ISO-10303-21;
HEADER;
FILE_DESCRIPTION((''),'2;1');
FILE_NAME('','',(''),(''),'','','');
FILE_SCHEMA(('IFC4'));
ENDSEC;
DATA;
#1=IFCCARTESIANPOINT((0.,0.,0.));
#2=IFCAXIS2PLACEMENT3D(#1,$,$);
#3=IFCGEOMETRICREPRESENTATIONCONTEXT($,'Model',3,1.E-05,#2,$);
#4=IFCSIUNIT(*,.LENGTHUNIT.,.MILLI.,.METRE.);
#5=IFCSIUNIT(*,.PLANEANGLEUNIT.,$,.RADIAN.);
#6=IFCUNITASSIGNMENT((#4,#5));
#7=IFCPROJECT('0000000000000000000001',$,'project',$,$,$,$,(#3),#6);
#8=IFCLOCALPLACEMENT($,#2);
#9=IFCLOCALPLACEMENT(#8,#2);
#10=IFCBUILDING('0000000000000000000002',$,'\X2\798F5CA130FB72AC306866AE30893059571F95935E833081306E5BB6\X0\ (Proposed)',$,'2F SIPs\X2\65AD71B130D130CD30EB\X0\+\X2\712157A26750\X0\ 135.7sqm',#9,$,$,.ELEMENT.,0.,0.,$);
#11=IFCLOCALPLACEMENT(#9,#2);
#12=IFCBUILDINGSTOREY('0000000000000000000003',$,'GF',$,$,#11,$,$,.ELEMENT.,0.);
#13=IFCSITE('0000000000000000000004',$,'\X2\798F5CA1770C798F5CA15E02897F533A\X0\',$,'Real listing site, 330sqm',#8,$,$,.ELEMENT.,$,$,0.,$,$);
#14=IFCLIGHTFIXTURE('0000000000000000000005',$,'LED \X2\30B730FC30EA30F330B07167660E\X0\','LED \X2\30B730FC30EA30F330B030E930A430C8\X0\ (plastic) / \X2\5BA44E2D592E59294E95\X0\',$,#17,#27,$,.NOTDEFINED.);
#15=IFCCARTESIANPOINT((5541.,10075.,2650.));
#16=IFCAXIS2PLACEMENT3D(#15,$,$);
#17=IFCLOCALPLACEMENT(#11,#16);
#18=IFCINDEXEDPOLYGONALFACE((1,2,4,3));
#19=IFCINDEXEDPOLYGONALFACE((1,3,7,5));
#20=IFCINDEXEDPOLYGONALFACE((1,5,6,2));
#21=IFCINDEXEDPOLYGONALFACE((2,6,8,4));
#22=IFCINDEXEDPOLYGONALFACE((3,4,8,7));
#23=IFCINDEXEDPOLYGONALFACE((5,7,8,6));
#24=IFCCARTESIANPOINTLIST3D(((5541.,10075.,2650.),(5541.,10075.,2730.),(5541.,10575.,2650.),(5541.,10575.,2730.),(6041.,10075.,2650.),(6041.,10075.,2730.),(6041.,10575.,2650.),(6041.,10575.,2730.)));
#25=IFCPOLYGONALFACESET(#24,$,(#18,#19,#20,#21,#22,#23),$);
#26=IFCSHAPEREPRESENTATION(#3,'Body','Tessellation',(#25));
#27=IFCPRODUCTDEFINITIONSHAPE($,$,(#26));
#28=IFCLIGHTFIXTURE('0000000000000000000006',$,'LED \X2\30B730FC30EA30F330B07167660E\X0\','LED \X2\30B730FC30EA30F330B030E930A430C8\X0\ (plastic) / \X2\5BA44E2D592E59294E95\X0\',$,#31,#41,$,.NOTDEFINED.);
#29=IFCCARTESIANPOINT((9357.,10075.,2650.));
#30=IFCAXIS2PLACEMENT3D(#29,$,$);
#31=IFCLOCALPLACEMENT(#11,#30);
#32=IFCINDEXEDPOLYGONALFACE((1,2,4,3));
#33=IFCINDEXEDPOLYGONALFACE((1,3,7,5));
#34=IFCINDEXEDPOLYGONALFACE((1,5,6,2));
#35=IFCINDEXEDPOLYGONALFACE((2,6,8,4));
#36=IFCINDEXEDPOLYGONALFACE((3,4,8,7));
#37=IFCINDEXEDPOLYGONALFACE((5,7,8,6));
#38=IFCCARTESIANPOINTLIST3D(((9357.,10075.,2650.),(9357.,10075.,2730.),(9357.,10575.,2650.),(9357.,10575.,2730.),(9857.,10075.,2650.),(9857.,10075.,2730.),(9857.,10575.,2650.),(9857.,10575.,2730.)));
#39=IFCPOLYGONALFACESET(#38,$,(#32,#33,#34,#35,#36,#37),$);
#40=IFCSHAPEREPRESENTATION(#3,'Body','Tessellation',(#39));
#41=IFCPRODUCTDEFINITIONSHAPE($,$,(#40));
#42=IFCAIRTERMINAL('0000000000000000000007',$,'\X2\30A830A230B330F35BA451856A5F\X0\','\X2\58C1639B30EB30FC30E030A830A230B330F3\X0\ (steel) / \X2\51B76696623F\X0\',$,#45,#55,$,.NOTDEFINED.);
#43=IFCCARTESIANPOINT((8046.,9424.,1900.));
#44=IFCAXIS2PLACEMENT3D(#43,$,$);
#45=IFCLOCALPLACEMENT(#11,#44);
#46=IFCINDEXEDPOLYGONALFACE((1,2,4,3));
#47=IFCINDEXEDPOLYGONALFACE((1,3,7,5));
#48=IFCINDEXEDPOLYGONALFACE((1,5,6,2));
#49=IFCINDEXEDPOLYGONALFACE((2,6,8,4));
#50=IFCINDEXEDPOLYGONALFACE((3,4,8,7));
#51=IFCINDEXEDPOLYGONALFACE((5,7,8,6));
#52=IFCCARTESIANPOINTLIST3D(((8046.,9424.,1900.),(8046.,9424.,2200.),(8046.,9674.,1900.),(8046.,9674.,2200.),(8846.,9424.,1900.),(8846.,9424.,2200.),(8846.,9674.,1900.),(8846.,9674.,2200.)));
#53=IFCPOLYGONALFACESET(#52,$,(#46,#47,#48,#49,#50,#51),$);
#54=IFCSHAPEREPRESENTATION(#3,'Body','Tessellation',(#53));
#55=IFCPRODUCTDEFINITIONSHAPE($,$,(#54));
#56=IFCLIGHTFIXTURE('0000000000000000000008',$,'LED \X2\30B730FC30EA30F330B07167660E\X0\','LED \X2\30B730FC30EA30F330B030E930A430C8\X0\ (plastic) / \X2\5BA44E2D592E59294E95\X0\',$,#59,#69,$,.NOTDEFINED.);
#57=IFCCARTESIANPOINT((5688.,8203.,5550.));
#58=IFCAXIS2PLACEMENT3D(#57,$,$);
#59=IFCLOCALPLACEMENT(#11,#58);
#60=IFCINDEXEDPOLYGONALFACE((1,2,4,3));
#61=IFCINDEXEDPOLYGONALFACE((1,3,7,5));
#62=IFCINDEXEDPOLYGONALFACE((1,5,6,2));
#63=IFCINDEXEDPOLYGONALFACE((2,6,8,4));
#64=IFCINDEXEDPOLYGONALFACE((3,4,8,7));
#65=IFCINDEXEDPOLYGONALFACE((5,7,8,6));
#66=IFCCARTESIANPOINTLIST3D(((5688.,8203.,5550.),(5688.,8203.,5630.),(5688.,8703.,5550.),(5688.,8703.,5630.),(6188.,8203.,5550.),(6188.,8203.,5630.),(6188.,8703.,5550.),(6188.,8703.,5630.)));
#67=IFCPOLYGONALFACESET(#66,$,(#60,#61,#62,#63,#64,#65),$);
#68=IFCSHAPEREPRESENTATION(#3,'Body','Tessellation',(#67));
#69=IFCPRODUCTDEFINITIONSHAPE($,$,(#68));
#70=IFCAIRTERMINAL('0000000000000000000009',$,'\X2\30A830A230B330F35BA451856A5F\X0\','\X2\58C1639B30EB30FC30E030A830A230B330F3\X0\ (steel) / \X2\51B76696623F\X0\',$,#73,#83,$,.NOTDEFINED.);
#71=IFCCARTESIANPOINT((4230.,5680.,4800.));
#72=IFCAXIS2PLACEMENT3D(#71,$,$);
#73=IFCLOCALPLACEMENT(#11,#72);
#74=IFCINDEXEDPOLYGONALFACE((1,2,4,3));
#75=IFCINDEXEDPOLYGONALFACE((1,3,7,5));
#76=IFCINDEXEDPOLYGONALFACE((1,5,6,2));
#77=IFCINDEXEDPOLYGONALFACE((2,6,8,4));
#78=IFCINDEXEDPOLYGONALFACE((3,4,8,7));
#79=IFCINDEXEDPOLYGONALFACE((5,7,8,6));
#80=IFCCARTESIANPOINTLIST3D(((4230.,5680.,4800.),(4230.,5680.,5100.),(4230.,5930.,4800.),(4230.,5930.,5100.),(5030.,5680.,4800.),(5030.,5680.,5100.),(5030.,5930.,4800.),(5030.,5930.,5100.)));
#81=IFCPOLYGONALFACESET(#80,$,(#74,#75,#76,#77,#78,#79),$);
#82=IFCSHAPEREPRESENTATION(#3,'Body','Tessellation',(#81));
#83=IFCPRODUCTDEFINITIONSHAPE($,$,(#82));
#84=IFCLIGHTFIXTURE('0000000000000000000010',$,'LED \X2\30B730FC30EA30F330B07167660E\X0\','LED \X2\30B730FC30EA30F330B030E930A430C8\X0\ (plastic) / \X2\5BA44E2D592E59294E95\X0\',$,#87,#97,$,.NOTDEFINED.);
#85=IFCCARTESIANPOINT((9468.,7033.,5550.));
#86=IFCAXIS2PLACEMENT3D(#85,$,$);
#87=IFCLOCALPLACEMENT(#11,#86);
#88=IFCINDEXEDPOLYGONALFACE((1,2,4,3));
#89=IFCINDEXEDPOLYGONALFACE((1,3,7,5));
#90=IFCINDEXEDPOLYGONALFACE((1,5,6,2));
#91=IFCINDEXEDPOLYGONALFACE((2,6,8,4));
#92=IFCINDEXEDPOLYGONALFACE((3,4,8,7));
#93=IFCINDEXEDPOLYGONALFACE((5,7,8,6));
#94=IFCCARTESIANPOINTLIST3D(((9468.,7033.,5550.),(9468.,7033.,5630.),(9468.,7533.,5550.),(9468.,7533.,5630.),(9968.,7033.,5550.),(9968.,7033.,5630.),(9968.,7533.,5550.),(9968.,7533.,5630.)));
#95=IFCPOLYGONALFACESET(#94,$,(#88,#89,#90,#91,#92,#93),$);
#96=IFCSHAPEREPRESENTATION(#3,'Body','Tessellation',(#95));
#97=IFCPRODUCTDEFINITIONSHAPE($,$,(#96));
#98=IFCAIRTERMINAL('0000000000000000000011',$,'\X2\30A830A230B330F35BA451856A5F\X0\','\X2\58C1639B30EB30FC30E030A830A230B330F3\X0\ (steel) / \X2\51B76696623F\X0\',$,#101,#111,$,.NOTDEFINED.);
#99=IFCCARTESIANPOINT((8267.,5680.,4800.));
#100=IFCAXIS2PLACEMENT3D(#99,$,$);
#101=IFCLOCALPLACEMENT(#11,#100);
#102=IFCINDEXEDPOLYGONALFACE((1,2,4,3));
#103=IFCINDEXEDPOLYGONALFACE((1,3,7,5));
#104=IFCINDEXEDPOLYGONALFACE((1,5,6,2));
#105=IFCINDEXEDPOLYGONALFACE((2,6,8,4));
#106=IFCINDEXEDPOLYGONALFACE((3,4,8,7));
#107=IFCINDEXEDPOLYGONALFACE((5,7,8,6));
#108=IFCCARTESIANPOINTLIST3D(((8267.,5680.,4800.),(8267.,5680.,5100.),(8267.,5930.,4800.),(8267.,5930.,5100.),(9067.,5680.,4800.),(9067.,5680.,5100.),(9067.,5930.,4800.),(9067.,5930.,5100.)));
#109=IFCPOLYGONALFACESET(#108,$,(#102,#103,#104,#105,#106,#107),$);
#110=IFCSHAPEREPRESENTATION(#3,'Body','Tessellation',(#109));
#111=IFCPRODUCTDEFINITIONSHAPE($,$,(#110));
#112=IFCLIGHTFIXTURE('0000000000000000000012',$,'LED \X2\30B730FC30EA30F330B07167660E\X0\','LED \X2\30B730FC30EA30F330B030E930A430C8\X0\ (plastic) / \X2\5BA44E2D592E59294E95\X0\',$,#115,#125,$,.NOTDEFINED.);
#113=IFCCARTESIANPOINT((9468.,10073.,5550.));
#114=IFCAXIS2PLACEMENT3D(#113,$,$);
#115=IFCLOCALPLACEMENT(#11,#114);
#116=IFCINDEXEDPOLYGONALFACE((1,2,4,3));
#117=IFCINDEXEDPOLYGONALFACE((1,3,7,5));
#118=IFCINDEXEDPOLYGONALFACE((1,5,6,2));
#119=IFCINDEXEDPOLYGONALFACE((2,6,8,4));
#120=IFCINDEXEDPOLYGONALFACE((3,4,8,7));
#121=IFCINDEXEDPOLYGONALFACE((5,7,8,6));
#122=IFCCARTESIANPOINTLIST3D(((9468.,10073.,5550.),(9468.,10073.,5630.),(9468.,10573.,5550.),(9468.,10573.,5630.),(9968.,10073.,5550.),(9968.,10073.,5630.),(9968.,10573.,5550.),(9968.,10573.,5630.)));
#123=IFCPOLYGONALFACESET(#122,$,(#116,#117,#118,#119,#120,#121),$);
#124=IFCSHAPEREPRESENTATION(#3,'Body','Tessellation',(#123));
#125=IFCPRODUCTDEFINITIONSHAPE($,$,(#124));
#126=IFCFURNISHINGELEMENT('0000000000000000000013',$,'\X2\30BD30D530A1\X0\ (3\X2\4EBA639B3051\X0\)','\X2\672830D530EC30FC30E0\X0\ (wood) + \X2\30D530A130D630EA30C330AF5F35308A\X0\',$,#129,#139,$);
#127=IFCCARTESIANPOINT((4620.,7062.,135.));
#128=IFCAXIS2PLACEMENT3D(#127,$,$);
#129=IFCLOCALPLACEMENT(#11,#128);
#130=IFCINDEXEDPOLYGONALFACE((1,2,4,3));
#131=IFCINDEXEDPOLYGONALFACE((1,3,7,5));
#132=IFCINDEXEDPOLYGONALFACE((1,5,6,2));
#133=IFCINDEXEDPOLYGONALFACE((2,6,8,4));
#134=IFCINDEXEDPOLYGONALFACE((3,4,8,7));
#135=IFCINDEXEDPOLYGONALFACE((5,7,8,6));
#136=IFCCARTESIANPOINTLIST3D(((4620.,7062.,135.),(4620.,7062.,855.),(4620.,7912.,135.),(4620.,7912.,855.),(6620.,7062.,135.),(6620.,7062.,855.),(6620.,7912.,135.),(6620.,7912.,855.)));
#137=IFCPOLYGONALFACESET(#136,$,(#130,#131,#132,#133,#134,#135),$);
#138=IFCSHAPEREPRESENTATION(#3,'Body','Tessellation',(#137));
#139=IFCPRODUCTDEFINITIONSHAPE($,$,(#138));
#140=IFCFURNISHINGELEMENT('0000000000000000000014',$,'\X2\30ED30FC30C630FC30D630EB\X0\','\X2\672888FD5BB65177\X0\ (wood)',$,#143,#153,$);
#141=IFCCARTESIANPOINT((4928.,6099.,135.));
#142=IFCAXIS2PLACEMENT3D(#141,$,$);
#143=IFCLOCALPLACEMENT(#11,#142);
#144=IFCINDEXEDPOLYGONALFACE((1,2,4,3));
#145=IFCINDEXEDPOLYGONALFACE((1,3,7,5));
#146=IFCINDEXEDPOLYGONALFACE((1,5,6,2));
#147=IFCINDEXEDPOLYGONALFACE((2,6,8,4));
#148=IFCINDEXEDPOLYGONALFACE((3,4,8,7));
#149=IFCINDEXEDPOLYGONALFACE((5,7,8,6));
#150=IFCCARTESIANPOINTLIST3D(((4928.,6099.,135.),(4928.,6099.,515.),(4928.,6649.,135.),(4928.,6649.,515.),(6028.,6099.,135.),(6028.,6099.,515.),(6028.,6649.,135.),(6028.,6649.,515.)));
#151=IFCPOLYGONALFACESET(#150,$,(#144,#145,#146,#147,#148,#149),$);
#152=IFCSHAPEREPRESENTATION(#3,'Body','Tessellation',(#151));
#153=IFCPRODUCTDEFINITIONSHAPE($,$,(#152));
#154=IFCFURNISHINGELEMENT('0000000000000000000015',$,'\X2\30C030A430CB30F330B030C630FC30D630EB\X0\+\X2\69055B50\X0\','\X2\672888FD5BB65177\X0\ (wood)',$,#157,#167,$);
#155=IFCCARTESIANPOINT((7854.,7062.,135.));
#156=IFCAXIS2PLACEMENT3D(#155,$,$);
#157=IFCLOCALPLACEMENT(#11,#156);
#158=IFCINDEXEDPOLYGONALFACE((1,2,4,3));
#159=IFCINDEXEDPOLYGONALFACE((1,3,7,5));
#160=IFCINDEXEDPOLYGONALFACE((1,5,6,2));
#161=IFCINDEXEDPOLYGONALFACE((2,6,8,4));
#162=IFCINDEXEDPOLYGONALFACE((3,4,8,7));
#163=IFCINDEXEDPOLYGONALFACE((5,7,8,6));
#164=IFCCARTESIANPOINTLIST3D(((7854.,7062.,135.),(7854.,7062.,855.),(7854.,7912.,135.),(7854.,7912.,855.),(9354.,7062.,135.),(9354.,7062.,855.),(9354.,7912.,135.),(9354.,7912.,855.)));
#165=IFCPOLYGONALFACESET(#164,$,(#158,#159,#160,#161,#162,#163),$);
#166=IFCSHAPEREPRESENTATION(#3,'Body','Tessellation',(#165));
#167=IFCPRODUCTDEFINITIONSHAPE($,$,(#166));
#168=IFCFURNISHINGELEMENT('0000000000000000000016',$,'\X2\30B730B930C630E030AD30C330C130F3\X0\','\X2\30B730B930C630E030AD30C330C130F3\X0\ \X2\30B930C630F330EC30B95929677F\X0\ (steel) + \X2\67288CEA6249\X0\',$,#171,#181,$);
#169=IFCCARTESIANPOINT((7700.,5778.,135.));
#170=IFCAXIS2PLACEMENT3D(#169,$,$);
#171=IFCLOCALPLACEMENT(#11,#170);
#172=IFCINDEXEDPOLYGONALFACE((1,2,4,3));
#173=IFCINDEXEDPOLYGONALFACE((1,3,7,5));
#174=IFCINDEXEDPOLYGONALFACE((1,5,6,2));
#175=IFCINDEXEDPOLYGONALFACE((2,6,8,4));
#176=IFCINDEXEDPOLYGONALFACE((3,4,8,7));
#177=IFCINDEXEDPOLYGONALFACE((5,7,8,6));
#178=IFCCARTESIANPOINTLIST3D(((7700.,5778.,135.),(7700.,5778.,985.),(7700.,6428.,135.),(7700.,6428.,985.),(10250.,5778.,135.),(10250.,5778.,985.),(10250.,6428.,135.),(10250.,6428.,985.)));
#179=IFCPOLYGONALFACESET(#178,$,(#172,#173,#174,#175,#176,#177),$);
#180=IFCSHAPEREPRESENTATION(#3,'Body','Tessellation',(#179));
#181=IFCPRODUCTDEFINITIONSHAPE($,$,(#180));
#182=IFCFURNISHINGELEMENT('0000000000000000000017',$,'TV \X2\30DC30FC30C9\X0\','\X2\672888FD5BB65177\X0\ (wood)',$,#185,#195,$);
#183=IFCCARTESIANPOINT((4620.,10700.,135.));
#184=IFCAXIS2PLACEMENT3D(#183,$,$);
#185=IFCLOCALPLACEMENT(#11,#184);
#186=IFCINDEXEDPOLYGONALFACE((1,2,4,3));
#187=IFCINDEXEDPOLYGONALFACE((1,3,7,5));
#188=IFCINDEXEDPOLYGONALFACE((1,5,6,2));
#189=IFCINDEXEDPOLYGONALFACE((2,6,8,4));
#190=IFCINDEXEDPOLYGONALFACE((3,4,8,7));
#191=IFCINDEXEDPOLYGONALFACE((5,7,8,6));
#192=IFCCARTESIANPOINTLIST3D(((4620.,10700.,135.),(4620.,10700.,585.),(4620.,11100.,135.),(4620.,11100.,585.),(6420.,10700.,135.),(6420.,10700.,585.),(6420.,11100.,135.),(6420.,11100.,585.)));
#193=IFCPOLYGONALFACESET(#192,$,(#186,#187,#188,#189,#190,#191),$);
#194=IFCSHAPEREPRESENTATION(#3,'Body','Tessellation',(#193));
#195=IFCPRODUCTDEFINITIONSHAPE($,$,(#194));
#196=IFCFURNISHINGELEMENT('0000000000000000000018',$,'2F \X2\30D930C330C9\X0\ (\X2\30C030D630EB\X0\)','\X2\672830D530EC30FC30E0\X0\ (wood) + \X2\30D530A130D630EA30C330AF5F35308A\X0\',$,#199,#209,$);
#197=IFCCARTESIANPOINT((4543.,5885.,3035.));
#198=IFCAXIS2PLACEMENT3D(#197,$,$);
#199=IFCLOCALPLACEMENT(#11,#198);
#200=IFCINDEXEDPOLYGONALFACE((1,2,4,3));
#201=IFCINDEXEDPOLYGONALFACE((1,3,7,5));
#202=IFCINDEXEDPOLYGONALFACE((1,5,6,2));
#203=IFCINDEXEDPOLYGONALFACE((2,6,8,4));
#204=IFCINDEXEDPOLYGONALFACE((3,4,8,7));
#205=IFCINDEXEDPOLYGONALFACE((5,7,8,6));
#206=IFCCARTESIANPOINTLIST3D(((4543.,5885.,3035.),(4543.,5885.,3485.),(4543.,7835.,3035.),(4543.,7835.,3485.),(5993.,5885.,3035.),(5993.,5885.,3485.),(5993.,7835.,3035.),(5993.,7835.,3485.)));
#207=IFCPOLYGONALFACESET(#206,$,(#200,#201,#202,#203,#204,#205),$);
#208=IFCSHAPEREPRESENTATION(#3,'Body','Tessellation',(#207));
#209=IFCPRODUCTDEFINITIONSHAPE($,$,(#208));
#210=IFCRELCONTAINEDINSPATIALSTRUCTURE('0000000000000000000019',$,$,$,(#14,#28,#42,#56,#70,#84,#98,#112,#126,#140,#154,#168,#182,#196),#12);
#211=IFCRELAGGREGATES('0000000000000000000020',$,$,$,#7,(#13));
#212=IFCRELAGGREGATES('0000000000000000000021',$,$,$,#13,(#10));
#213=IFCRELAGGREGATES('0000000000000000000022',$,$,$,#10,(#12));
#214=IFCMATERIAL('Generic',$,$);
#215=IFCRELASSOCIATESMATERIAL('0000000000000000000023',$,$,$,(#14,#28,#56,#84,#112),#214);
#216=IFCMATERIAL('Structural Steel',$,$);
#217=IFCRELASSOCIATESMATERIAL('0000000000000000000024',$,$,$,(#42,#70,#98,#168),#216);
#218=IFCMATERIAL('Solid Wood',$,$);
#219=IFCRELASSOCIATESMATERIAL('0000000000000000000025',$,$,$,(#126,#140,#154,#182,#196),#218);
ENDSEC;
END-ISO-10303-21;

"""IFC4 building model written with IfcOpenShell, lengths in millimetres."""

from ifc_helpers import new_model, si_unit, frame, frame_2d, origin, place, context, project, spatial, rectangle, extrude, material, element, save


model = new_model("IFC4")

# Units and contexts
model_context = context("Model", 3, precision=1e-05, world=origin())
ifc_project = project(units=[si_unit("LENGTHUNIT", "METRE", prefix="MILLI"), si_unit("PLANEANGLEUNIT", "RADIAN")], contexts=[model_context])

# Site, building, storey
site_placement = place(None, origin())
site = spatial("IfcSite", under=ifc_project, at=site_placement, Name="福岡県福岡市西区", ObjectType="Real listing site, 330sqm", CompositionType="ELEMENT", RefElevation=0.0)
building_placement = place(site_placement, origin())
building = spatial("IfcBuilding", under=site, at=building_placement, Name="福岡・犬と暮らす土間広めの家 (Proposed)", ObjectType="2F SIPs断熱パネル+無垢材 135.7sqm", CompositionType="ELEMENT", ElevationOfRefHeight=0.0, ElevationOfTerrain=0.0)
storey_placement = place(building_placement, origin())
storey = spatial("IfcBuildingStorey", under=building, at=storey_placement, Name="GF", CompositionType="ELEMENT", Elevation=0.0)

# Shared definitions
ifc_material_1 = material(Name="Solid Wood")

# Shared definitions
ifc_material_2 = material(Name="Structural Steel")

# Shared definitions
ifc_material_3 = material(Name="Generic")

# Light fixtures
light_fixture_1_placement = place(storey_placement, frame((5541.0, 10075.0, 2650.0)))
element("IfcLightFixture", 1, at=light_fixture_1_placement, inside=storey, material=ifc_material_3, Name="LED シーリング照明", Description="LED シーリングライト (plastic) / 室中央天井", PredefinedType="NOTDEFINED", context=model_context, shape_type="SweptSolid", body=[
    extrude(rectangle(XDim=500.0, YDim=500.0, at=frame_2d((250.0, 250.0))), frame((5541.0, 10075.0, 2650.0)), (0.0, 0.0, 1.0), 80.0),
])
light_fixture_2_placement = place(storey_placement, frame((9357.0, 10075.0, 2650.0)))
element("IfcLightFixture", 2, at=light_fixture_2_placement, inside=storey, material=ifc_material_3, Name="LED シーリング照明", Description="LED シーリングライト (plastic) / 室中央天井", PredefinedType="NOTDEFINED", context=model_context, shape_type="SweptSolid", body=[
    extrude(rectangle(XDim=500.0, YDim=500.0, at=frame_2d((250.0, 250.0))), frame((9357.0, 10075.0, 2650.0)), (0.0, 0.0, 1.0), 80.0),
])

# Air terminal
air_terminal_1_placement = place(storey_placement, frame((8046.0, 9424.0, 1900.0)))
element("IfcAirTerminal", 3, at=air_terminal_1_placement, inside=storey, material=ifc_material_2, Name="エアコン室内機", Description="壁掛ルームエアコン (steel) / 冷暖房", PredefinedType="NOTDEFINED", context=model_context, shape_type="SweptSolid", body=[
    extrude(rectangle(XDim=800.0, YDim=250.0, at=frame_2d((400.0, 125.0))), frame((8046.0, 9424.0, 1900.0)), (0.0, 0.0, 1.0), 300.0),
])

# Light fixture
light_fixture_3_placement = place(storey_placement, frame((5688.0, 8203.0, 5550.0)))
element("IfcLightFixture", 4, at=light_fixture_3_placement, inside=storey, material=ifc_material_3, Name="LED シーリング照明", Description="LED シーリングライト (plastic) / 室中央天井", PredefinedType="NOTDEFINED", context=model_context, shape_type="SweptSolid", body=[
    extrude(rectangle(XDim=500.0, YDim=500.0, at=frame_2d((250.0, 250.0))), frame((5688.0, 8203.0, 5550.0)), (0.0, 0.0, 1.0), 80.0),
])

# Air terminal
air_terminal_2_placement = place(storey_placement, frame((4230.0, 5680.0, 4800.0)))
element("IfcAirTerminal", 5, at=air_terminal_2_placement, inside=storey, material=ifc_material_2, Name="エアコン室内機", Description="壁掛ルームエアコン (steel) / 冷暖房", PredefinedType="NOTDEFINED", context=model_context, shape_type="SweptSolid", body=[
    extrude(rectangle(XDim=800.0, YDim=250.0, at=frame_2d((400.0, 125.0))), frame((4230.0, 5680.0, 4800.0)), (0.0, 0.0, 1.0), 300.0),
])

# Light fixture
light_fixture_4_placement = place(storey_placement, frame((9468.0, 7033.0, 5550.0)))
element("IfcLightFixture", 6, at=light_fixture_4_placement, inside=storey, material=ifc_material_3, Name="LED シーリング照明", Description="LED シーリングライト (plastic) / 室中央天井", PredefinedType="NOTDEFINED", context=model_context, shape_type="SweptSolid", body=[
    extrude(rectangle(XDim=500.0, YDim=500.0, at=frame_2d((250.0, 250.0))), frame((9468.0, 7033.0, 5550.0)), (0.0, 0.0, 1.0), 80.0),
])

# Air terminal
air_terminal_3_placement = place(storey_placement, frame((8267.0, 5680.0, 4800.0)))
element("IfcAirTerminal", 7, at=air_terminal_3_placement, inside=storey, material=ifc_material_2, Name="エアコン室内機", Description="壁掛ルームエアコン (steel) / 冷暖房", PredefinedType="NOTDEFINED", context=model_context, shape_type="SweptSolid", body=[
    extrude(rectangle(XDim=800.0, YDim=250.0, at=frame_2d((400.0, 125.0))), frame((8267.0, 5680.0, 4800.0)), (0.0, 0.0, 1.0), 300.0),
])

# Light fixture
light_fixture_5_placement = place(storey_placement, frame((9468.0, 10073.0, 5550.0)))
element("IfcLightFixture", 8, at=light_fixture_5_placement, inside=storey, material=ifc_material_3, Name="LED シーリング照明", Description="LED シーリングライト (plastic) / 室中央天井", PredefinedType="NOTDEFINED", context=model_context, shape_type="SweptSolid", body=[
    extrude(rectangle(XDim=500.0, YDim=500.0, at=frame_2d((250.0, 250.0))), frame((9468.0, 10073.0, 5550.0)), (0.0, 0.0, 1.0), 80.0),
])

# Furnishing elements
furnishing_1_placement = place(storey_placement, frame((4620.0, 7062.0, 135.0)))
element("IfcFurnishingElement", 9, at=furnishing_1_placement, inside=storey, material=ifc_material_1, Name="ソファ (3人掛け)", Description="木フレーム (wood) + ファブリック張り", context=model_context, shape_type="SweptSolid", body=[
    extrude(rectangle(XDim=2000.0, YDim=850.0, at=frame_2d((1000.0, 425.0))), frame((4620.0, 7062.0, 135.0)), (0.0, 0.0, 1.0), 720.0),
])
furnishing_2_placement = place(storey_placement, frame((4928.0, 6099.0, 135.0)))
element("IfcFurnishingElement", 10, at=furnishing_2_placement, inside=storey, material=ifc_material_1, Name="ローテーブル", Description="木製家具 (wood)", context=model_context, shape_type="SweptSolid", body=[
    extrude(rectangle(XDim=1100.0, YDim=550.0, at=frame_2d((550.0, 275.0))), frame((4928.0, 6099.0, 135.0)), (0.0, 0.0, 1.0), 380.0),
])
furnishing_3_placement = place(storey_placement, frame((7854.0, 7062.0, 135.0)))
element("IfcFurnishingElement", 11, at=furnishing_3_placement, inside=storey, material=ifc_material_1, Name="ダイニングテーブル+椅子", Description="木製家具 (wood)", context=model_context, shape_type="SweptSolid", body=[
    extrude(rectangle(XDim=1500.0, YDim=850.0, at=frame_2d((750.0, 425.0))), frame((7854.0, 7062.0, 135.0)), (0.0, 0.0, 1.0), 720.0),
])
furnishing_4_placement = place(storey_placement, frame((7700.0, 5778.0, 135.0)))
element("IfcFurnishingElement", 12, at=furnishing_4_placement, inside=storey, material=ifc_material_2, Name="システムキッチン", Description="システムキッチン ステンレス天板 (steel) + 木質扉", context=model_context, shape_type="SweptSolid", body=[
    extrude(rectangle(XDim=2550.0, YDim=650.0, at=frame_2d((1275.0, 325.0))), frame((7700.0, 5778.0, 135.0)), (0.0, 0.0, 1.0), 850.0),
])
furnishing_5_placement = place(storey_placement, frame((4620.0, 10700.0, 135.0)))
element("IfcFurnishingElement", 13, at=furnishing_5_placement, inside=storey, material=ifc_material_1, Name="TV ボード", Description="木製家具 (wood)", context=model_context, shape_type="SweptSolid", body=[
    extrude(rectangle(XDim=1800.0, YDim=400.0, at=frame_2d((900.0, 200.0))), frame((4620.0, 10700.0, 135.0)), (0.0, 0.0, 1.0), 450.0),
])
furnishing_6_placement = place(storey_placement, frame((4543.0, 5885.0, 3035.0)))
element("IfcFurnishingElement", 14, at=furnishing_6_placement, inside=storey, material=ifc_material_1, Name="2F ベッド (ダブル)", Description="木フレーム (wood) + ファブリック張り", context=model_context, shape_type="SweptSolid", body=[
    extrude(rectangle(XDim=1450.0, YDim=1950.0, at=frame_2d((725.0, 975.0))), frame((4543.0, 5885.0, 3035.0)), (0.0, 0.0, 1.0), 450.0),
])

save(model, "model.ifc")
